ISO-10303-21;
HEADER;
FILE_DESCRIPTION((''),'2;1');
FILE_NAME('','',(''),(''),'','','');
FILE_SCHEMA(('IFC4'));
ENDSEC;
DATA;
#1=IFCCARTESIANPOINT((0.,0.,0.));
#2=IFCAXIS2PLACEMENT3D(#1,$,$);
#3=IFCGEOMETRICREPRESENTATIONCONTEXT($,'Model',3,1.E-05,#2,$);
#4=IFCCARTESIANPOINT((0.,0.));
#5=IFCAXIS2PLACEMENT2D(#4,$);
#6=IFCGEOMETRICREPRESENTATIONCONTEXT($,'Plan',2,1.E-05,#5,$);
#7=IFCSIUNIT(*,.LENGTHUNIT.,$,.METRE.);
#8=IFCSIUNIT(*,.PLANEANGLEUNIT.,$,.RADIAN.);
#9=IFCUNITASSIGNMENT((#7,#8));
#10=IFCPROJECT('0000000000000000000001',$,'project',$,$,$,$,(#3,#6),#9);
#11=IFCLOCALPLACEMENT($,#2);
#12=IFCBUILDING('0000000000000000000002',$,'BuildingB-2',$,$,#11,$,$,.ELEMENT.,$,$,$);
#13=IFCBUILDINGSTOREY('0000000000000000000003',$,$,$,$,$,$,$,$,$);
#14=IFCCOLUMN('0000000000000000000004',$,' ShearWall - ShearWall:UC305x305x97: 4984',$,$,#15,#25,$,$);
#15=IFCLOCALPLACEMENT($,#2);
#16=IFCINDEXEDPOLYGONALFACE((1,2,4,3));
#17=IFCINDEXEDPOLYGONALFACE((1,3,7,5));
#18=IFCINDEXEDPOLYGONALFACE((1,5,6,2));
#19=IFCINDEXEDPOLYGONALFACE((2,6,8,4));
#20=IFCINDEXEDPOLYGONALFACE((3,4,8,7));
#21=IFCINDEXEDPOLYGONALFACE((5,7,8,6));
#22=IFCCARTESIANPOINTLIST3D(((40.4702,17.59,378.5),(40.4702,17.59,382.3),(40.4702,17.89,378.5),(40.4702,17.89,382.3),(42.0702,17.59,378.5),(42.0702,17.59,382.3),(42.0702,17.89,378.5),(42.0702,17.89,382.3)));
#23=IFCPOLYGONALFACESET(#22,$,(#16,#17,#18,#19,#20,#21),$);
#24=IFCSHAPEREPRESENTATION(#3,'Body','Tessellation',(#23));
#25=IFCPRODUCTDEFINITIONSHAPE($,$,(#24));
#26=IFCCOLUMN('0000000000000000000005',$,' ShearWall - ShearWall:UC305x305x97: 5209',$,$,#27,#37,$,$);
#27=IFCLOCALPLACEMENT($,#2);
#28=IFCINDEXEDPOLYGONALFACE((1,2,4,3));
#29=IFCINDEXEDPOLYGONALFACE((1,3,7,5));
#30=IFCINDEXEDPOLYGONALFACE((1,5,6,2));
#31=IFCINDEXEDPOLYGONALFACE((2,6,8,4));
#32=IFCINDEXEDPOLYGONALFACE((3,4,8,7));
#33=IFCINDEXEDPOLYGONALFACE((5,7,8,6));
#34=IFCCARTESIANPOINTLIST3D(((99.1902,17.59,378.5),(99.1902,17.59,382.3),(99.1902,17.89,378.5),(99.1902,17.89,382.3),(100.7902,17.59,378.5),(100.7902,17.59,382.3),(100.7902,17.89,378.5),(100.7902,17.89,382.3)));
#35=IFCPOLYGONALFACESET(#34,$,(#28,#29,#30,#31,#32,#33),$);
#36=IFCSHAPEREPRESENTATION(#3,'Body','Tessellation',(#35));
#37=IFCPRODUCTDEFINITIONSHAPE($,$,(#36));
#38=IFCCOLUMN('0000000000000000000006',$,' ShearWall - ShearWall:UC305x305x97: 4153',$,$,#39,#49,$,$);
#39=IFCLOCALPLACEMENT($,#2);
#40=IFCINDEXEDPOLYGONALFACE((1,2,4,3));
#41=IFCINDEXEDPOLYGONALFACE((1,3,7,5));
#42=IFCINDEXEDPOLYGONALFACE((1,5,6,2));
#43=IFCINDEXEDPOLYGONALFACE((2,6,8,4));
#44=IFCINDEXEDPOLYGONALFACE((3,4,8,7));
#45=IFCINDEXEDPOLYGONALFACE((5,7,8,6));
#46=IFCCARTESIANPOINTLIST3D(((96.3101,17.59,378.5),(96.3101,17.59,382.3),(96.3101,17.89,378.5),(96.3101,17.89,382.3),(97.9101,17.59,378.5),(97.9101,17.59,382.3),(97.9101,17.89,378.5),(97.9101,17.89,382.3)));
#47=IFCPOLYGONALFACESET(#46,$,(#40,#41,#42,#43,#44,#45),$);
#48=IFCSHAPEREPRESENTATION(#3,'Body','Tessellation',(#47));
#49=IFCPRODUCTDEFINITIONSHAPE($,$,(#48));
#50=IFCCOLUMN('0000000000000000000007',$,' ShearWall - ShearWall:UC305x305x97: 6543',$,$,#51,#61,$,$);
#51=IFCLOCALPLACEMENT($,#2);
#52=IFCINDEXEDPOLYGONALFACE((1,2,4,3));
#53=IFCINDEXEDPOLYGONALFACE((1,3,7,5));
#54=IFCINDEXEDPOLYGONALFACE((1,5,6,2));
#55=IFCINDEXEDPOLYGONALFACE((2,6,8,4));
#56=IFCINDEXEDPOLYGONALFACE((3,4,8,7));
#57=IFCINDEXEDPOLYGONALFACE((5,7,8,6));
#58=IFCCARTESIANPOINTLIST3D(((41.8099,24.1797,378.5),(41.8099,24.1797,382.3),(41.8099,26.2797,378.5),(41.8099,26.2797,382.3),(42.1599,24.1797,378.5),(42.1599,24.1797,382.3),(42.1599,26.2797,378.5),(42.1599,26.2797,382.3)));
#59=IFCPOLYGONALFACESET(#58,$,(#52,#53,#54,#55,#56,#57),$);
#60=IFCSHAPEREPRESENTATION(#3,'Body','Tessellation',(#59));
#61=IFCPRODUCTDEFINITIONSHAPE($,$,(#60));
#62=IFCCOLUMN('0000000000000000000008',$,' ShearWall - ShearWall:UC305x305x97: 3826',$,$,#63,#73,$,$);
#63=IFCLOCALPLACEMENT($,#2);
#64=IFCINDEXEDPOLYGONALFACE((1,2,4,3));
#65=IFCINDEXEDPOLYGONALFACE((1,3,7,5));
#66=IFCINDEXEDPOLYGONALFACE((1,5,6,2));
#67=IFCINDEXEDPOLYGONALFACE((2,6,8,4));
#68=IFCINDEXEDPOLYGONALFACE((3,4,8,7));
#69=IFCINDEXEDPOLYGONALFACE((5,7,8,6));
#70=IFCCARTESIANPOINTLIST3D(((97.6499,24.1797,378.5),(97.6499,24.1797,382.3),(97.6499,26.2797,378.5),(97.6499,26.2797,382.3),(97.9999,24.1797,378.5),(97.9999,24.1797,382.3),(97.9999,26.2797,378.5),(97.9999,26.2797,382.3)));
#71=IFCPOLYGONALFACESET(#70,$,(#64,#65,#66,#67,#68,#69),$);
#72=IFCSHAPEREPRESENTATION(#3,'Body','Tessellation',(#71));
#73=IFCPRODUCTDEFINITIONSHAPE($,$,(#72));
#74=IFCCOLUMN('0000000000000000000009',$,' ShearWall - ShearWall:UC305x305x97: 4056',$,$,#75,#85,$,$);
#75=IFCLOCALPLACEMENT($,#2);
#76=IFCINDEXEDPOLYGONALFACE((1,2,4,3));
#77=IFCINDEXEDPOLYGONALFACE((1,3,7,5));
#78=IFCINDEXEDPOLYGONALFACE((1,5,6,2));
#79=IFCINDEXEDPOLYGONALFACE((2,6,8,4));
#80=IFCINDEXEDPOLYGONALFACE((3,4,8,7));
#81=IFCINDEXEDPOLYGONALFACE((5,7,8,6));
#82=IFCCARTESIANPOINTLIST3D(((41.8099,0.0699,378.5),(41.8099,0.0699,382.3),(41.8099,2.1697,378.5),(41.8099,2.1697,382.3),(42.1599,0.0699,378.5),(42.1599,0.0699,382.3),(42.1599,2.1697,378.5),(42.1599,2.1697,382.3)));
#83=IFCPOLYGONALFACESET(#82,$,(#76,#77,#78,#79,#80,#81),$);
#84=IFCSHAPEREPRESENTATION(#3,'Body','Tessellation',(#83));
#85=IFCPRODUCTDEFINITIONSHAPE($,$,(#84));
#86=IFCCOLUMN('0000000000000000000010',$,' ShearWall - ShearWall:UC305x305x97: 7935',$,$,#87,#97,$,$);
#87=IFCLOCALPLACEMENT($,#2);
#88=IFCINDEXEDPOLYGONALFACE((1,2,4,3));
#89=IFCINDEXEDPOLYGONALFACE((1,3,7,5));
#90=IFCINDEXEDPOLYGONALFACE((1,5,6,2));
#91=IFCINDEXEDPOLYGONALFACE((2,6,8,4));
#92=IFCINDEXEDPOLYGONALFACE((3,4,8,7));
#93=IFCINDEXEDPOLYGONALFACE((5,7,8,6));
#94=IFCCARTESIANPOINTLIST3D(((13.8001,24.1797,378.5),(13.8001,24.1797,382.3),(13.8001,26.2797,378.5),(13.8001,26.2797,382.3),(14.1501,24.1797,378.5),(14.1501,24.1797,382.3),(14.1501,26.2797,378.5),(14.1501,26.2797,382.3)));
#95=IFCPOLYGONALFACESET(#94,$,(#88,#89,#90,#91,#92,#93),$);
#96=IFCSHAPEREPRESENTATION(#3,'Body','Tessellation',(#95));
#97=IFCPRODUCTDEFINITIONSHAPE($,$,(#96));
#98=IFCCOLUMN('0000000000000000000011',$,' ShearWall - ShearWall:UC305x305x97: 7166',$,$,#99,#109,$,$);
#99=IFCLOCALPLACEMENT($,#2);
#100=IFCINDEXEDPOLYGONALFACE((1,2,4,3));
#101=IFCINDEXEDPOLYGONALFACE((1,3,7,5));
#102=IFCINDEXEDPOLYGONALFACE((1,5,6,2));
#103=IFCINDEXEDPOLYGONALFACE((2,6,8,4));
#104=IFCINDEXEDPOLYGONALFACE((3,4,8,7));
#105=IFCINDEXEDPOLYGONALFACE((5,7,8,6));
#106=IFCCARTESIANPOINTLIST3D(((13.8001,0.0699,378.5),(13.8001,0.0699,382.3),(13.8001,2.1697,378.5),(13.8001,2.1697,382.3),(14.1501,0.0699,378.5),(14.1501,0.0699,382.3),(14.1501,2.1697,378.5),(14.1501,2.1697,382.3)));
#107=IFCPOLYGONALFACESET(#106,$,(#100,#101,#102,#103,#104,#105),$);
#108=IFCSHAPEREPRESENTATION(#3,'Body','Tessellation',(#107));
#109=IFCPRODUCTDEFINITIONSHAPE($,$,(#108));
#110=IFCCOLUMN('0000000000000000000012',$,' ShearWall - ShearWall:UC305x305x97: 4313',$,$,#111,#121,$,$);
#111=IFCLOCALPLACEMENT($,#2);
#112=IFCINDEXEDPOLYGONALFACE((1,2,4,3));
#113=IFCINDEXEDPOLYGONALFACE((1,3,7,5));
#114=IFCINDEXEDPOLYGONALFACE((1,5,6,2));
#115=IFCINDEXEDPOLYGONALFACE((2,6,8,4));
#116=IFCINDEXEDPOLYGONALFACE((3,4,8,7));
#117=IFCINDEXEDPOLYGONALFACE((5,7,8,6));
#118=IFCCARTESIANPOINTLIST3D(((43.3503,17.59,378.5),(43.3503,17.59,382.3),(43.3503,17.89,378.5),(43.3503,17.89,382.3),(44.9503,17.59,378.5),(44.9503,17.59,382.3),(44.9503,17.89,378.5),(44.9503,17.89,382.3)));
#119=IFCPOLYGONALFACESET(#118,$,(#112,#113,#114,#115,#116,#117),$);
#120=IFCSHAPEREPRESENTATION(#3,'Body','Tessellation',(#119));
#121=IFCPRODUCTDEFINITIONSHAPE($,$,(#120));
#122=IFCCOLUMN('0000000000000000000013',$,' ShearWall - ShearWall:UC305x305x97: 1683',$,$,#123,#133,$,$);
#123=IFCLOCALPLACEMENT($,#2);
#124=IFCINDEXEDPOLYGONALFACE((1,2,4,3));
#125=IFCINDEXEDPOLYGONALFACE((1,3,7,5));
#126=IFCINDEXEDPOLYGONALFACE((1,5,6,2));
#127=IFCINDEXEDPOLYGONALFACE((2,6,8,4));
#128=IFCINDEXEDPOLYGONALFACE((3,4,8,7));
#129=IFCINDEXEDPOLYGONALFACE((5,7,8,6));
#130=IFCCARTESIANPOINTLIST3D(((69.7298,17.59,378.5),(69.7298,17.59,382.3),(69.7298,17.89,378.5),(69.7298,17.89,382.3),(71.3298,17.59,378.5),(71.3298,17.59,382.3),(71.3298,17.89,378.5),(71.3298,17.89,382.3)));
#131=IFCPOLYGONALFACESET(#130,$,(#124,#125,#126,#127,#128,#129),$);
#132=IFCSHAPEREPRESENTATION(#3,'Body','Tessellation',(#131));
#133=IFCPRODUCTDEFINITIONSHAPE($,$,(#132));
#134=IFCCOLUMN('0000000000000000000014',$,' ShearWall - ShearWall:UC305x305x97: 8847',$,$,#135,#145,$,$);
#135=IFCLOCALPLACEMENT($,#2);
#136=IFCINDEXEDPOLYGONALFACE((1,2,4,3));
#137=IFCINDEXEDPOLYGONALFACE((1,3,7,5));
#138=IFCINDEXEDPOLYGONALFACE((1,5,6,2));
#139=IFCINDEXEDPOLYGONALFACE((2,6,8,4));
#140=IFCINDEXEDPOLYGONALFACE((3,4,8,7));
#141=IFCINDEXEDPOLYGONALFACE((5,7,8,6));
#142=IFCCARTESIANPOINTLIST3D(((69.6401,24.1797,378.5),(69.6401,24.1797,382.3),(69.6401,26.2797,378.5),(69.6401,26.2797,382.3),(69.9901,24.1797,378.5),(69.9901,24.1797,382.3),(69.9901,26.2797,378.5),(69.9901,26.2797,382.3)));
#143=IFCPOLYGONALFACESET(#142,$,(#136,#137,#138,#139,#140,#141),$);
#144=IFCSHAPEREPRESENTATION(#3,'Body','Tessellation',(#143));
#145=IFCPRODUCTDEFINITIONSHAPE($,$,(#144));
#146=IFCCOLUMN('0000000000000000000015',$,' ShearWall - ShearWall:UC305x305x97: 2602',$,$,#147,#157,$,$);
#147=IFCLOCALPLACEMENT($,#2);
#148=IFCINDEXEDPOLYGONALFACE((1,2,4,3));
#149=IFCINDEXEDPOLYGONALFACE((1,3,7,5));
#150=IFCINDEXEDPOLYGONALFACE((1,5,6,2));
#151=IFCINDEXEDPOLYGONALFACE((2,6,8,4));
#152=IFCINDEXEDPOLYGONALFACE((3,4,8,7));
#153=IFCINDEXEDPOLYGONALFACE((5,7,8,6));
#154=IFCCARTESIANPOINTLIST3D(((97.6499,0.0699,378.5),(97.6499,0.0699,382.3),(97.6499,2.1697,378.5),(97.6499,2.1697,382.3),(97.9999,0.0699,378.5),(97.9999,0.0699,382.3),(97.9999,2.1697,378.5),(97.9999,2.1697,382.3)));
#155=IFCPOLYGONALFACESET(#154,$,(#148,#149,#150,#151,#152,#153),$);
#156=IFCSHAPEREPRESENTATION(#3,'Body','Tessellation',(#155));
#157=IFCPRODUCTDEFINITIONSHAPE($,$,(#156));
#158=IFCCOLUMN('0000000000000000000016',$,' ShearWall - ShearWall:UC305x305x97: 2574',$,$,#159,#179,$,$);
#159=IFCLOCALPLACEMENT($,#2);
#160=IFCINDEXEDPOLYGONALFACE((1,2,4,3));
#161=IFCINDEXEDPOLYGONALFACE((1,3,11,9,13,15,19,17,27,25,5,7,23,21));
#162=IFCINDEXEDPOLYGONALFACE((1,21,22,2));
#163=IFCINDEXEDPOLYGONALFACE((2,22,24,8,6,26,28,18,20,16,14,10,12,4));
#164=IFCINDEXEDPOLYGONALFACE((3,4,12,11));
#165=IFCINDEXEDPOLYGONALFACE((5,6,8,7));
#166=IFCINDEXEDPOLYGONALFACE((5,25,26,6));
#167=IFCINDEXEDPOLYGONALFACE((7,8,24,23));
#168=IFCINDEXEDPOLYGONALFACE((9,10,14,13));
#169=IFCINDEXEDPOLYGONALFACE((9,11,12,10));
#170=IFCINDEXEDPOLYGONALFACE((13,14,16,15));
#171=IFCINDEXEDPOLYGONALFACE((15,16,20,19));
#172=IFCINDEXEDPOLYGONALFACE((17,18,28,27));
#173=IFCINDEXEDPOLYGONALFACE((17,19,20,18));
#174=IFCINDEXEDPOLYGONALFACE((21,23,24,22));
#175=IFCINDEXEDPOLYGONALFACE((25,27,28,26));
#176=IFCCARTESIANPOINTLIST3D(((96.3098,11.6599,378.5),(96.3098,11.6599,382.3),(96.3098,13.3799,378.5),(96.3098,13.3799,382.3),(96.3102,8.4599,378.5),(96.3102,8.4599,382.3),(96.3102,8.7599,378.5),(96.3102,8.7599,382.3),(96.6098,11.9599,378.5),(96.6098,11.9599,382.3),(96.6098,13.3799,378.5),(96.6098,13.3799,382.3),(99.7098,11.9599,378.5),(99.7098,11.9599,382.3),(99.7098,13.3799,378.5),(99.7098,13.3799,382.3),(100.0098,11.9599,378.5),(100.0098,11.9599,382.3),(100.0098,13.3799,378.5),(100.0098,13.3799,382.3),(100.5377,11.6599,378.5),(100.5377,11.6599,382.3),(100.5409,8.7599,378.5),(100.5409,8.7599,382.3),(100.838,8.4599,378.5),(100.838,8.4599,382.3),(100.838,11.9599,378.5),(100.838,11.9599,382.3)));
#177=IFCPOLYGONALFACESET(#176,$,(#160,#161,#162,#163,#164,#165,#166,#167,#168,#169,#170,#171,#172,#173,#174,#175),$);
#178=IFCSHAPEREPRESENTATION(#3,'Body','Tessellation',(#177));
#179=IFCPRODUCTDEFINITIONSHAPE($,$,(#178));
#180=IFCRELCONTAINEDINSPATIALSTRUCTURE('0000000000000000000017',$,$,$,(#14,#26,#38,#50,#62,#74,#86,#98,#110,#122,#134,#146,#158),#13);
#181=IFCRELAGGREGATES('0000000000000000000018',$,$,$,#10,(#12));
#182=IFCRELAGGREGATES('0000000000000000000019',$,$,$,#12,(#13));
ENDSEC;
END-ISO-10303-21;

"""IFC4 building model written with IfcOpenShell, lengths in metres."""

from ifc_helpers import new_model, si_unit, origin, origin_with_axes, origin_2d, place, context, project, spatial, polyline, outline, extrude, element, save


model = new_model("IFC4")

# Units and contexts
model_context = context("Model", 3, precision=1e-05, world=origin())
plan_context = context("Plan", 2, precision=1e-05, world=origin_2d())
ifc_project = project(units=[si_unit("LENGTHUNIT", "METRE"), si_unit("PLANEANGLEUNIT", "RADIAN")], contexts=[model_context, plan_context])

# Building, storey
building_placement = place(None, origin())
building = spatial("IfcBuilding", under=ifc_project, at=building_placement, Name="BuildingB-2", CompositionType="ELEMENT")
storey = spatial("IfcBuildingStorey", under=building)

# Columns
column_1_placement = place(None, origin_with_axes())
element("IfcColumn", 1, at=column_1_placement, inside=storey, Name=" ShearWall - ShearWall:UC305x305x97: 4984", context=model_context, shape_type="SweptSolid", body=[
    extrude(outline(polyline([(42.0702, 17.59, 382.3), (42.0702, 17.89, 382.3), (40.4702, 17.89, 382.3), (40.4702, 17.59, 382.3), (42.0702, 17.59, 382.3)])), None, (0.0, 0.0, -1.0), 3.8),
])
column_2_placement = place(None, origin_with_axes())
element("IfcColumn", 2, at=column_2_placement, inside=storey, Name=" ShearWall - ShearWall:UC305x305x97: 5209", context=model_context, shape_type="SweptSolid", body=[
    extrude(outline(polyline([(100.7902, 17.59, 382.3), (100.7902, 17.89, 382.3), (99.1902, 17.89, 382.3), (99.1902, 17.59, 382.3), (100.7902, 17.59, 382.3)])), None, (0.0, 0.0, -1.0), 3.8),
])
column_3_placement = place(None, origin_with_axes())
element("IfcColumn", 3, at=column_3_placement, inside=storey, Name=" ShearWall - ShearWall:UC305x305x97: 4153", context=model_context, shape_type="SweptSolid", body=[
    extrude(outline(polyline([(97.9101, 17.59, 382.3), (97.9101, 17.89, 382.3), (96.3101, 17.89, 382.3), (96.3101, 17.59, 382.3), (97.9101, 17.59, 382.3)])), None, (0.0, 0.0, -1.0), 3.8),
])
column_4_placement = place(None, origin_with_axes())
element("IfcColumn", 4, at=column_4_placement, inside=storey, Name=" ShearWall - ShearWall:UC305x305x97: 6543", context=model_context, shape_type="SweptSolid", body=[
    extrude(outline(polyline([(41.8099, 26.2797, 382.3), (42.1599, 26.2797, 382.3), (42.1599, 24.1797, 382.3), (41.8099, 24.1797, 382.3), (41.8099, 26.2797, 382.3)])), None, (0.0, 0.0, -1.0), 3.8),
])
column_5_placement = place(None, origin_with_axes())
element("IfcColumn", 5, at=column_5_placement, inside=storey, Name=" ShearWall - ShearWall:UC305x305x97: 3826", context=model_context, shape_type="SweptSolid", body=[
    extrude(outline(polyline([(97.6499, 26.2797, 382.3), (97.9999, 26.2797, 382.3), (97.9999, 24.1797, 382.3), (97.6499, 24.1797, 382.3), (97.6499, 26.2797, 382.3)])), None, (0.0, 0.0, -1.0), 3.8),
])
column_6_placement = place(None, origin_with_axes())
element("IfcColumn", 6, at=column_6_placement, inside=storey, Name=" ShearWall - ShearWall:UC305x305x97: 4056", context=model_context, shape_type="SweptSolid", body=[
    extrude(outline(polyline([(41.8099, 2.1697, 382.3), (42.1599, 2.1697, 382.3), (42.1599, 0.0699, 382.3), (41.8099, 0.0699, 382.3), (41.8099, 2.1697, 382.3)])), None, (0.0, 0.0, -1.0), 3.8),
])
column_7_placement = place(None, origin_with_axes())
element("IfcColumn", 7, at=column_7_placement, inside=storey, Name=" ShearWall - ShearWall:UC305x305x97: 7935", context=model_context, shape_type="SweptSolid", body=[
    extrude(outline(polyline([(14.1501, 26.2797, 382.3), (13.8001, 26.2797, 382.3), (13.8001, 24.1797, 382.3), (14.1501, 24.1797, 382.3), (14.1501, 26.2797, 382.3)])), None, (0.0, 0.0, -1.0), 3.8),
])
column_8_placement = place(None, origin_with_axes())
element("IfcColumn", 8, at=column_8_placement, inside=storey, Name=" ShearWall - ShearWall:UC305x305x97: 7166", context=model_context, shape_type="SweptSolid", body=[
    extrude(outline(polyline([(14.1501, 2.1697, 382.3), (13.8001, 2.1697, 382.3), (13.8001, 0.0699, 382.3), (14.1501, 0.0699, 382.3), (14.1501, 2.1697, 382.3)])), None, (0.0, 0.0, -1.0), 3.8),
])
column_9_placement = place(None, origin_with_axes())
element("IfcColumn", 9, at=column_9_placement, inside=storey, Name=" ShearWall - ShearWall:UC305x305x97: 4313", context=model_context, shape_type="SweptSolid", body=[
    extrude(outline(polyline([(44.9503, 17.59, 382.3), (44.9503, 17.89, 382.3), (43.3503, 17.89, 382.3), (43.3503, 17.59, 382.3), (44.9503, 17.59, 382.3)])), None, (0.0, 0.0, -1.0), 3.8),
])
column_10_placement = place(None, origin_with_axes())
element("IfcColumn", 10, at=column_10_placement, inside=storey, Name=" ShearWall - ShearWall:UC305x305x97: 1683", context=model_context, shape_type="SweptSolid", body=[
    extrude(outline(polyline([(69.7298, 17.59, 382.3), (69.7298, 17.89, 382.3), (71.3298, 17.89, 382.3), (71.3298, 17.59, 382.3), (69.7298, 17.59, 382.3)])), None, (0.0, 0.0, -1.0), 3.8),
])
column_11_placement = place(None, origin_with_axes())
element("IfcColumn", 11, at=column_11_placement, inside=storey, Name=" ShearWall - ShearWall:UC305x305x97: 8847", context=model_context, shape_type="SweptSolid", body=[
    extrude(outline(polyline([(69.9901, 26.2797, 382.3), (69.6401, 26.2797, 382.3), (69.6401, 24.1797, 382.3), (69.9901, 24.1797, 382.3), (69.9901, 26.2797, 382.3)])), None, (0.0, 0.0, -1.0), 3.8),
])
column_12_placement = place(None, origin_with_axes())
element("IfcColumn", 12, at=column_12_placement, inside=storey, Name=" ShearWall - ShearWall:UC305x305x97: 2602", context=model_context, shape_type="SweptSolid", body=[
    extrude(outline(polyline([(97.6499, 2.1697, 382.3), (97.9999, 2.1697, 382.3), (97.9999, 0.0699, 382.3), (97.6499, 0.0699, 382.3), (97.6499, 2.1697, 382.3)])), None, (0.0, 0.0, -1.0), 3.8),
])
column_13_placement = place(None, origin_with_axes())
element("IfcColumn", 13, at=column_13_placement, inside=storey, Name=" ShearWall - ShearWall:UC305x305x97: 2574", context=model_context, shape_type="SweptSolid", body=[
    extrude(outline(polyline([(100.838, 8.4599, 382.3), (96.3102, 8.4599, 382.3), (96.3102, 8.7599, 382.3), (100.5409, 8.7599, 382.3), (100.5377, 11.6599, 382.3), (96.3098, 11.6599, 382.3), (96.3098, 13.3799, 382.3), (96.6098, 13.3799, 382.3), (96.6098, 11.9599, 382.3), (99.7098, 11.9599, 382.3), (99.7098, 13.3799, 382.3), (100.0098, 13.3799, 382.3), (100.0098, 11.9599, 382.3), (100.838, 11.9599, 382.3), (100.838, 8.4599, 382.3)])), None, (0.0, 0.0, -1.0), 3.8),
])

save(model, "model.ifc")
